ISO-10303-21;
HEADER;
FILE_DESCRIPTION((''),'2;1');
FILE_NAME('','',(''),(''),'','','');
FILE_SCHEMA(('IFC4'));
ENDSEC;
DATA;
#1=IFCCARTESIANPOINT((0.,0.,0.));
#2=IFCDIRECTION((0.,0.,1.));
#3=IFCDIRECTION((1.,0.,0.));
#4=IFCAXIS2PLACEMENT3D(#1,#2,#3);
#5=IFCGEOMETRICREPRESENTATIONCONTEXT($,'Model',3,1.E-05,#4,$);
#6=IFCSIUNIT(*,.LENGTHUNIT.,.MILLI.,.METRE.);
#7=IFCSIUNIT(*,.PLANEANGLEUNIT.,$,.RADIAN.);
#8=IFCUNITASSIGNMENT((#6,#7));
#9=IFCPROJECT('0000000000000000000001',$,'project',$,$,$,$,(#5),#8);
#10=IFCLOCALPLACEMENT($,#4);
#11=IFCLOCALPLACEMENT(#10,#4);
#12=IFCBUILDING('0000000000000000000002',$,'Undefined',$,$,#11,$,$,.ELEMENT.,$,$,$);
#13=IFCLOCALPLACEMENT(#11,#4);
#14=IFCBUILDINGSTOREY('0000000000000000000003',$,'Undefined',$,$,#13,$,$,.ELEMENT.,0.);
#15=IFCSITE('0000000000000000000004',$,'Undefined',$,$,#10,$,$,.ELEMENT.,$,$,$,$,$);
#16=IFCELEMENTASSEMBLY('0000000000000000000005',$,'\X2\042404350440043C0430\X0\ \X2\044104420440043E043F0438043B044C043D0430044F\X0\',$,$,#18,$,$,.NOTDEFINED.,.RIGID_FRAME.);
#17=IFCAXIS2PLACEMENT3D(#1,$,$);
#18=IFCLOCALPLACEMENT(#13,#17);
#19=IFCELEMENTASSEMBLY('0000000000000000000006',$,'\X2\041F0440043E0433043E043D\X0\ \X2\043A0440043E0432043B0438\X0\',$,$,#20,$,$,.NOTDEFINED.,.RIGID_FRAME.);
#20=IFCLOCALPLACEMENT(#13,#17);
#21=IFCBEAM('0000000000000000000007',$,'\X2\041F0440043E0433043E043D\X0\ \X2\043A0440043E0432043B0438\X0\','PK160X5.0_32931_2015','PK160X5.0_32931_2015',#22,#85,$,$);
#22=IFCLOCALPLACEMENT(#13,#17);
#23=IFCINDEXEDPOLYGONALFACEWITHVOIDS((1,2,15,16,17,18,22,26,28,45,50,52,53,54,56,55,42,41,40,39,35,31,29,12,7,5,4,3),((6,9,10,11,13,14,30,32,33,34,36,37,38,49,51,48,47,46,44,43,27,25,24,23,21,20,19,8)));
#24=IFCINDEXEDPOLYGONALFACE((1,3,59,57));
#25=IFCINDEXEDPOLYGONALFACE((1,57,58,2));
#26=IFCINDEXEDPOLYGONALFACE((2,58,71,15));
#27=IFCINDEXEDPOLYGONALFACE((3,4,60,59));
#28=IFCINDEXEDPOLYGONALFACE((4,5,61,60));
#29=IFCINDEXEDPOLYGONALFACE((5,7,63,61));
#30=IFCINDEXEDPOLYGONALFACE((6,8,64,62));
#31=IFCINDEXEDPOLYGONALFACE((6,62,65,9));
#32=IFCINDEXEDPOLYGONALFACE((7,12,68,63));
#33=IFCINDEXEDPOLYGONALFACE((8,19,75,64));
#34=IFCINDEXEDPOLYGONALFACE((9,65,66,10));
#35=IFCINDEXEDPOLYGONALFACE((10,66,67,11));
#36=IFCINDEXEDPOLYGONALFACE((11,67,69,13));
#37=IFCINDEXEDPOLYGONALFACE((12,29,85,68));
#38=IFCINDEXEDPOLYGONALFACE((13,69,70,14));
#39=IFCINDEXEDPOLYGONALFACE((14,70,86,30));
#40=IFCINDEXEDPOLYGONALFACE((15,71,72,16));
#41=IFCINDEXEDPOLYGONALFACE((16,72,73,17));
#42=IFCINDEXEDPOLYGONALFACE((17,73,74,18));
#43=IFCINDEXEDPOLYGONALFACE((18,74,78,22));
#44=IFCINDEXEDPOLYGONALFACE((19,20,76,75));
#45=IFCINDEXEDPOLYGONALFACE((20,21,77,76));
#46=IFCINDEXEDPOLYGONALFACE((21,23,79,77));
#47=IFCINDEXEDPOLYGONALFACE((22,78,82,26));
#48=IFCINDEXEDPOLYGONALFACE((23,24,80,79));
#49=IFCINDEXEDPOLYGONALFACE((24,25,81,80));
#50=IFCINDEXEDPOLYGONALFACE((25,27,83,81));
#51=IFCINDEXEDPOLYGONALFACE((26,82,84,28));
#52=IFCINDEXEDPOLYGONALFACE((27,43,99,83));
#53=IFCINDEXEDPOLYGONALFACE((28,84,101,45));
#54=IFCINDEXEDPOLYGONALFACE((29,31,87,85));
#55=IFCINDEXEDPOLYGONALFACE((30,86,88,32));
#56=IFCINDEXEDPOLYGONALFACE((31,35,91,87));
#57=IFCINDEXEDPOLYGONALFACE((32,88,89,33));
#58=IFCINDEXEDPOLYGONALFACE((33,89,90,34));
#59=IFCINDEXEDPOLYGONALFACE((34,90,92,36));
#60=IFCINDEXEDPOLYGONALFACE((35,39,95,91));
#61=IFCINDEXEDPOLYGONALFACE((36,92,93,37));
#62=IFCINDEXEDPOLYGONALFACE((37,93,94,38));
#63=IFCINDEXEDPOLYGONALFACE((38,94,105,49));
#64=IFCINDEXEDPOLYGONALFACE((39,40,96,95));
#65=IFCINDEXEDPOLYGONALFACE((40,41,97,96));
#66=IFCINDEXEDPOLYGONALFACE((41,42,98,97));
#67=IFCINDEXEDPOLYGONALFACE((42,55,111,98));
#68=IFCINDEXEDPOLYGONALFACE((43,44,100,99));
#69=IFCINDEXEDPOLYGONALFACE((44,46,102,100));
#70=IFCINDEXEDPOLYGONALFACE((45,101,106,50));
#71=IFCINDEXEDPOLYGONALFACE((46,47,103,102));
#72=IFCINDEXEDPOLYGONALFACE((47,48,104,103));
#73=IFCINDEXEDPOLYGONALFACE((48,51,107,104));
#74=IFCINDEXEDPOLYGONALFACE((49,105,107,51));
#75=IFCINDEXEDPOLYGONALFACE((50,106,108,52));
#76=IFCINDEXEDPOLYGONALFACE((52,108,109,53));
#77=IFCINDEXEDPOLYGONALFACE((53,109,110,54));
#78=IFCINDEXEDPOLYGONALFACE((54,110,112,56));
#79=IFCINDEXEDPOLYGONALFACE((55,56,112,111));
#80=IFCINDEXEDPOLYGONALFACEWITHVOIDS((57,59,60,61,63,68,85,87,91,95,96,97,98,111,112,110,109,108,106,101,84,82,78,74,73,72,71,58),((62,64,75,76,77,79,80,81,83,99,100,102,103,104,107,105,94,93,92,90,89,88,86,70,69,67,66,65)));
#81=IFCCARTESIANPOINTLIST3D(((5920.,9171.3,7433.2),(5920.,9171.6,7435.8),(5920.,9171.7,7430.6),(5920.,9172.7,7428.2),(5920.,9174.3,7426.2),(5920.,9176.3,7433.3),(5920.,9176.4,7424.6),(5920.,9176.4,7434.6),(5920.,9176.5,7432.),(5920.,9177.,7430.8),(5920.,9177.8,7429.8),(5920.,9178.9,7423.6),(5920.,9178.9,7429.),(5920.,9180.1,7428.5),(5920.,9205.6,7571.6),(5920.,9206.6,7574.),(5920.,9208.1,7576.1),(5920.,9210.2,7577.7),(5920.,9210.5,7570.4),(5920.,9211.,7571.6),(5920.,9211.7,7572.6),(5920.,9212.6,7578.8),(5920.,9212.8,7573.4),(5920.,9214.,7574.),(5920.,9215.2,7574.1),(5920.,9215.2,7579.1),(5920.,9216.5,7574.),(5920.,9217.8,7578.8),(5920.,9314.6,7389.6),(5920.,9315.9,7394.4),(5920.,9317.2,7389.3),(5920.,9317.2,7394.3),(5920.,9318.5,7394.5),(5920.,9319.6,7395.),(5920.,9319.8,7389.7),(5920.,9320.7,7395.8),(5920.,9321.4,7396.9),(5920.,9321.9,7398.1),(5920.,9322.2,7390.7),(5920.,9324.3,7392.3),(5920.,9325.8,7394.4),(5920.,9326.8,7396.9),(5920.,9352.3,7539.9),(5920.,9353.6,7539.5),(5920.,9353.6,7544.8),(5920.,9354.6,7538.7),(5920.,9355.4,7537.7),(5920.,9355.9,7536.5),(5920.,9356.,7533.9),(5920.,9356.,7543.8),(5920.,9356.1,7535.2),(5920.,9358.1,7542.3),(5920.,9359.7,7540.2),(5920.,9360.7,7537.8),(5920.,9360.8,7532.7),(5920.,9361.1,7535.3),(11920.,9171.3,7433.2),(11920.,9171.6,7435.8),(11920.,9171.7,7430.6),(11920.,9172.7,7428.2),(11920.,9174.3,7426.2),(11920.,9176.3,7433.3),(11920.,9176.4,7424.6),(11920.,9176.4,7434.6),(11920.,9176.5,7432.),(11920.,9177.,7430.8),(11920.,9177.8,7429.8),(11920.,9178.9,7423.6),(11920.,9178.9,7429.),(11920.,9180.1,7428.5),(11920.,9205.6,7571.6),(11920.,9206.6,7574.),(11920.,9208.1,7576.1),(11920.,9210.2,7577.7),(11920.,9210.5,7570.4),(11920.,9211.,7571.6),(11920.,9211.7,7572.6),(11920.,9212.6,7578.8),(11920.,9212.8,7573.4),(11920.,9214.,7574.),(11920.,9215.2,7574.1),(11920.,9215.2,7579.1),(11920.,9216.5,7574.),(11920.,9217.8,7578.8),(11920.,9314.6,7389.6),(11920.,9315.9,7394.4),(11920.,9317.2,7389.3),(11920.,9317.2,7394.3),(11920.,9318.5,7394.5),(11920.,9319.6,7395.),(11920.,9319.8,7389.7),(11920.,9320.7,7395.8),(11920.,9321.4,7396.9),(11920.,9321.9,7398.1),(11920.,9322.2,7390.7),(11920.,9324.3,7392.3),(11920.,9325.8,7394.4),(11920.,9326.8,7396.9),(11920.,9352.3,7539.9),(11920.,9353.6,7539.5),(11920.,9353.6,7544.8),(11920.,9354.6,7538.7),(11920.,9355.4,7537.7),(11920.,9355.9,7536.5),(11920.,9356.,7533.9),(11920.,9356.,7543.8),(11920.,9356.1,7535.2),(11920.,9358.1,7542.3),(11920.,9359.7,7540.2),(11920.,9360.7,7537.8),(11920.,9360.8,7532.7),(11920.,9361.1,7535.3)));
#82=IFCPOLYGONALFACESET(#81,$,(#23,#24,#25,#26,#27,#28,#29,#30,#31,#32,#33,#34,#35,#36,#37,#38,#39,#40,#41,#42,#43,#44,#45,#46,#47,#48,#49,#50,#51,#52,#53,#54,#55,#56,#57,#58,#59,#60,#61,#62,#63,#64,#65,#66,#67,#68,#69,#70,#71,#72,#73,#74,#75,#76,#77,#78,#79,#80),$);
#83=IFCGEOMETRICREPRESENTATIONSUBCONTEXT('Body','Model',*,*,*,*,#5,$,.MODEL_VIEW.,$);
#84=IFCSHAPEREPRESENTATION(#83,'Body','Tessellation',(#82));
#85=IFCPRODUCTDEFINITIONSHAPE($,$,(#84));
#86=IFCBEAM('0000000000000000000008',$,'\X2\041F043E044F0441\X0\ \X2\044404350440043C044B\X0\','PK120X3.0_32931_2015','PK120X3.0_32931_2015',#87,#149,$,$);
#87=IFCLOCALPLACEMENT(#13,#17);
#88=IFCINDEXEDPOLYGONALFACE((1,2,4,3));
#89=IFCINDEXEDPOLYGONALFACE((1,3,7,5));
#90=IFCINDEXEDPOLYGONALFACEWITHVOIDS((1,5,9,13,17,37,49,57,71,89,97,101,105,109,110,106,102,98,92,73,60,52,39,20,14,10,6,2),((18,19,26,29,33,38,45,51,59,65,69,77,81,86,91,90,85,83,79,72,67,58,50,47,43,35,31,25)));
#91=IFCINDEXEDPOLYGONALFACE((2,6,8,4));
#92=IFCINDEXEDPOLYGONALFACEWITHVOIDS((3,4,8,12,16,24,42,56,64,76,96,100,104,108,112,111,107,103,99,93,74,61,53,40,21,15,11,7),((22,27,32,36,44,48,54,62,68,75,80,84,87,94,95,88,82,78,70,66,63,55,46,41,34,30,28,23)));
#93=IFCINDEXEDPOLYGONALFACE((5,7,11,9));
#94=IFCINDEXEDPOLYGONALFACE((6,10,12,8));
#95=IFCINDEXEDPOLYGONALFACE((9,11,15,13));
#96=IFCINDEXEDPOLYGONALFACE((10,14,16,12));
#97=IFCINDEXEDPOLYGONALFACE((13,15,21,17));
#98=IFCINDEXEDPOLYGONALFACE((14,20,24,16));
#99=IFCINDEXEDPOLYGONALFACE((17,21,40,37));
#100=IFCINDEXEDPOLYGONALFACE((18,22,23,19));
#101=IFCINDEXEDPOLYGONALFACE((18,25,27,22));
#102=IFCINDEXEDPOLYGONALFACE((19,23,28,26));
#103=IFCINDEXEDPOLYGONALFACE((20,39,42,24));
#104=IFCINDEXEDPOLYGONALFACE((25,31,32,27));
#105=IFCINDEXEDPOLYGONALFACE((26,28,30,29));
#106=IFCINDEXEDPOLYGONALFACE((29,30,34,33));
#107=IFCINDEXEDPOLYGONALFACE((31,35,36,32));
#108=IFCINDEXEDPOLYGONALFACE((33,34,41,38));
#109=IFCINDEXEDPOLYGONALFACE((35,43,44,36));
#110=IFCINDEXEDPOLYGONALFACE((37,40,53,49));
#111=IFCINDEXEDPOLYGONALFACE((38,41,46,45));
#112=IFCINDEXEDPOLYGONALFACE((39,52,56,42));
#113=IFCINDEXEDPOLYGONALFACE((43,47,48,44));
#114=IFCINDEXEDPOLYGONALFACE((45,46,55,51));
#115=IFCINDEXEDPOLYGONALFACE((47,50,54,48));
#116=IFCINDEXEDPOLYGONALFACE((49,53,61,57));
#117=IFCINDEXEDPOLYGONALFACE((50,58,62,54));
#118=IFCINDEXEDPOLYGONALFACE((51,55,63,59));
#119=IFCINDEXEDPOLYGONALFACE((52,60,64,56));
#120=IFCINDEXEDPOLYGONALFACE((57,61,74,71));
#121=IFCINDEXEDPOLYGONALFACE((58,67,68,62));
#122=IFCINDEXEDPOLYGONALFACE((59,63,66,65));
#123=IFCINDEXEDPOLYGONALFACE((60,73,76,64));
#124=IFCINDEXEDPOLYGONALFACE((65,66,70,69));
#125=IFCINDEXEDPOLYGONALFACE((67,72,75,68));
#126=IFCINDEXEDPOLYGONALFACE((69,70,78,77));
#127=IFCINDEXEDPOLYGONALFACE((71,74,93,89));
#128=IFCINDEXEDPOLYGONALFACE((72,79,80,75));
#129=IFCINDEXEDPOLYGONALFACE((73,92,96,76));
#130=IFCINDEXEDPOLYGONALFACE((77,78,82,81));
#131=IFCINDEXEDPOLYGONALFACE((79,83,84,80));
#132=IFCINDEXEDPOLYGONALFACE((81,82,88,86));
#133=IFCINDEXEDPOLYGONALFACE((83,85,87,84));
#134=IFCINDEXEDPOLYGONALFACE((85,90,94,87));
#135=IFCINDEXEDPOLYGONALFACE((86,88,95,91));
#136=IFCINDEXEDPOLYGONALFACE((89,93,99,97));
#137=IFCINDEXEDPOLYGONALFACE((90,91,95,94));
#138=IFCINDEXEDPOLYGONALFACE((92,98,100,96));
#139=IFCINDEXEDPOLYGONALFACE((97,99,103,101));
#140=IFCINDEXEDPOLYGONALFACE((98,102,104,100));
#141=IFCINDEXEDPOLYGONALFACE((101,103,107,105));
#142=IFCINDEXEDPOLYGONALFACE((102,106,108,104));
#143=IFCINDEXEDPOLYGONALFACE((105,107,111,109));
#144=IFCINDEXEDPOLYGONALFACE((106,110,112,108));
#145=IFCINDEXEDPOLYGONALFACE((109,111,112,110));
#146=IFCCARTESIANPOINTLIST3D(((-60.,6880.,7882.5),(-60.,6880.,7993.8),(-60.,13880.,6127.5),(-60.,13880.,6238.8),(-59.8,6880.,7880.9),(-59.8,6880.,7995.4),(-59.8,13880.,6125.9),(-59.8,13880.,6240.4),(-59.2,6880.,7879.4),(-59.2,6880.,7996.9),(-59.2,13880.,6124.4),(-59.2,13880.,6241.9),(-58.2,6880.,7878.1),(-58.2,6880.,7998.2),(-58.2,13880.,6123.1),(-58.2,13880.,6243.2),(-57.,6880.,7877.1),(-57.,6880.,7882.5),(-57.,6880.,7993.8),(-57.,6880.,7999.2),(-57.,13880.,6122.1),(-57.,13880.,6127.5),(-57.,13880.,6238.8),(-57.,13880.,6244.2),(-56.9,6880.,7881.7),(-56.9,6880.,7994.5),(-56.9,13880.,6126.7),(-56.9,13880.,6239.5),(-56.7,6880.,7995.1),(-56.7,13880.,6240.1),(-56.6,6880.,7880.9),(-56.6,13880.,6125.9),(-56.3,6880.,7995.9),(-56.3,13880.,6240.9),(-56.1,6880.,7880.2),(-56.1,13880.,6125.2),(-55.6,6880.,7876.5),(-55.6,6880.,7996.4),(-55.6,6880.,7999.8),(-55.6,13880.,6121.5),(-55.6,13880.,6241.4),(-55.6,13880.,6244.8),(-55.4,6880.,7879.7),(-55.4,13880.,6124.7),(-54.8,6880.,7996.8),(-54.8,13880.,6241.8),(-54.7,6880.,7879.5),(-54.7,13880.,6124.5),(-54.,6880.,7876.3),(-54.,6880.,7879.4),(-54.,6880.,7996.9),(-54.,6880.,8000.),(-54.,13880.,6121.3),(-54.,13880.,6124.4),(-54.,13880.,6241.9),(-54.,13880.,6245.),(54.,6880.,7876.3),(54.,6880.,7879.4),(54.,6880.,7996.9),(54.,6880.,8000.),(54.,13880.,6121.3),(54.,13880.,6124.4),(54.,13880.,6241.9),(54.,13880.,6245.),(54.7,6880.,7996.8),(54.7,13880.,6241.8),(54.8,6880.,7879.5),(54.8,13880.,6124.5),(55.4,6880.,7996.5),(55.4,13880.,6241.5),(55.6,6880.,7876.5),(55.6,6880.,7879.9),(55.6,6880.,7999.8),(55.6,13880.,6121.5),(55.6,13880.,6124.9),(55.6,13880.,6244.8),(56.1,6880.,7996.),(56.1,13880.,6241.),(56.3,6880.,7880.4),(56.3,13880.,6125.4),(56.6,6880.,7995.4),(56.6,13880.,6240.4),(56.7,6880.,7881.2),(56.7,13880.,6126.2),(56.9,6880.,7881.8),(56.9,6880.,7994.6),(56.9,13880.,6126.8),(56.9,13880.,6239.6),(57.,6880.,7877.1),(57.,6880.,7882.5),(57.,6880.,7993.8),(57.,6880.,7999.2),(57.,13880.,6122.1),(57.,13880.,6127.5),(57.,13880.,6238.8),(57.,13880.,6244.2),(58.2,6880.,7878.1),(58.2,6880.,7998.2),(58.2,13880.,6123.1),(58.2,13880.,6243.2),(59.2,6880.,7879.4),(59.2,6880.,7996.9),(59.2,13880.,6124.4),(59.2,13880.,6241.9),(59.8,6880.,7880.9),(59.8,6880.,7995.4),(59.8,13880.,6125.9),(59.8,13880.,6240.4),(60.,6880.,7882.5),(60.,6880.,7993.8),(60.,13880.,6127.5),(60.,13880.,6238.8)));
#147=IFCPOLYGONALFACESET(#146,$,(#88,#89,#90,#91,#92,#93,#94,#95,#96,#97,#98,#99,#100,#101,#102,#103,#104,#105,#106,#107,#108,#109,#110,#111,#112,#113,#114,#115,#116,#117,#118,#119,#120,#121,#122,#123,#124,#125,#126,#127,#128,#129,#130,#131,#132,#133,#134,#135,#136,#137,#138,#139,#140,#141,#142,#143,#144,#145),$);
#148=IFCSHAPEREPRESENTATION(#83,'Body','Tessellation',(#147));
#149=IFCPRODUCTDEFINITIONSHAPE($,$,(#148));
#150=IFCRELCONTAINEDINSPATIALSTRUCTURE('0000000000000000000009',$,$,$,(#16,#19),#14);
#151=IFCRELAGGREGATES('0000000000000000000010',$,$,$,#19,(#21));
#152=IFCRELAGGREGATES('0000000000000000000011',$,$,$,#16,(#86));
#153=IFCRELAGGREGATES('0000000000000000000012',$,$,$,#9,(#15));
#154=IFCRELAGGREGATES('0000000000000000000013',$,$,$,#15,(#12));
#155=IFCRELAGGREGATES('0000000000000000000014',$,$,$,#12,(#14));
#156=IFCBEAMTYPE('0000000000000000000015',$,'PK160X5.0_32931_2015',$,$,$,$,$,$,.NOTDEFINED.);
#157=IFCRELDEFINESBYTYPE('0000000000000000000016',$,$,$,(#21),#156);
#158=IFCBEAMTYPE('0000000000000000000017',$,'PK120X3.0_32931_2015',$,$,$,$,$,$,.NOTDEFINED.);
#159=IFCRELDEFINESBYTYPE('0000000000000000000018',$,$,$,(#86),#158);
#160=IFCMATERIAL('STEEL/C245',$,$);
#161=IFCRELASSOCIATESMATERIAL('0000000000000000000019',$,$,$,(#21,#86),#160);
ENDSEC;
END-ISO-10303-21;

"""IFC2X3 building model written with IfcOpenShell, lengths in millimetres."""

from ifc_helpers import new_model, si_unit, frame, origin_with_axes, origin_2d_with_axis, place, context, subcontext, project, spatial, hollow_rectangle, extrude, clip, halfspace, material, type_object, element, aggregate, save


model = new_model("IFC2X3")

# Units and contexts
model_context = context("Model", 3, precision=1e-05, world=origin_with_axes())
body_context = subcontext(model_context, "Body", "Model", "MODEL_VIEW")
ifc_project = project(units=[si_unit("LENGTHUNIT", "METRE", prefix="MILLI"), si_unit("PLANEANGLEUNIT", "RADIAN")], contexts=[model_context])

# Site, building, storey
site_placement = place(None, origin_with_axes())
site = spatial("IfcSite", under=ifc_project, at=site_placement, Name="Undefined", CompositionType="ELEMENT")
building_placement = place(site_placement, origin_with_axes())
building = spatial("IfcBuilding", under=site, at=building_placement, Name="Undefined", CompositionType="ELEMENT")
storey_placement = place(building_placement, origin_with_axes())
storey = spatial("IfcBuildingStorey", under=building, at=storey_placement, Name="Undefined", CompositionType="ELEMENT", Elevation=0.0)

# Shared definitions
ifc_material = material(Name="STEEL/C245")

# Element assembly
assembly_1_placement = place(storey_placement, origin_with_axes())
assembly_1 = element("IfcElementAssembly", 1, at=assembly_1_placement, inside=storey, Name="Ферма стропильная", AssemblyPlace="NOTDEFINED", PredefinedType="RIGID_FRAME")

# Element assembly, beam
beam_type_1 = type_object("IfcBeamType", Name="PK160X5.0_32931_2015", PredefinedType="NOTDEFINED")
assembly_2_placement = place(storey_placement, origin_with_axes())
assembly_2 = element("IfcElementAssembly", 2, at=assembly_2_placement, inside=storey, Name="Прогон кровли", AssemblyPlace="NOTDEFINED", PredefinedType="RIGID_FRAME")
beam_1_placement = place(assembly_2_placement, frame((5920.0, 9266.2, 7484.2), z_axis=(0.0, 0.243188, 0.969979), x_axis=(1.0, 0.0, 0.0)))
beam_1 = element("IfcBeam", 3, at=beam_1_placement, type_object=beam_type_1, material=ifc_material, Name="Прогон кровли", Description="PK160X5.0_32931_2015", ObjectType="PK160X5.0_32931_2015", context=body_context, shape_type="SweptSolid", body=[
    extrude(hollow_rectangle(XDim=160.0, YDim=160.0, WallThickness=5.0, InnerFilletRadius=5.0, OuterFilletRadius=10.0, at=origin_2d_with_axis()), frame((6000.0, 0.0, 0.0), z_axis=(-1.0, 0.0, 0.0), x_axis=(0.0, -1.0, 0.0)), (0.0, 0.0, 1.0), 6000.0),
])
aggregate(assembly_2, [beam_1])

# Beam
beam_type_2 = type_object("IfcBeamType", Name="PK120X3.0_32931_2015", PredefinedType="NOTDEFINED")
beam_2_placement = place(assembly_1_placement, frame((0.0, 13865.4, 6186.8), z_axis=(0.0, 0.243188, 0.969979), x_axis=(0.0, -0.969979, 0.243188)))
beam_2 = element("IfcBeam", 4, at=beam_2_placement, type_object=beam_type_2, material=ifc_material, Name="Пояс фермы", Description="PK120X3.0_32931_2015", ObjectType="PK120X3.0_32931_2015", context=body_context, shape_type="Clipping", body=[
    clip(clip(extrude(hollow_rectangle(XDim=120.0, YDim=120.0, WallThickness=3.0, InnerFilletRadius=3.0, OuterFilletRadius=6.0, at=origin_2d_with_axis()), frame((7232.0, 0.0, 0.0), z_axis=(-1.0, 0.0, 0.0), x_axis=(0.0, -1.0, 0.0)), (0.0, 0.0, 1.0), 7277.4), halfspace(frame((7216.6, 0.0, 60.0), z_axis=(0.969979, 0.0, -0.243188), x_axis=(0.243188, 0.0, 0.969979)), False)), halfspace(frame((0.0, 0.0, 60.0), z_axis=(0.969979, 0.0, -0.243188), x_axis=(0.243188, 0.0, 0.969979)), True)),
])
aggregate(assembly_1, [beam_2])

save(model, "model.ifc")
